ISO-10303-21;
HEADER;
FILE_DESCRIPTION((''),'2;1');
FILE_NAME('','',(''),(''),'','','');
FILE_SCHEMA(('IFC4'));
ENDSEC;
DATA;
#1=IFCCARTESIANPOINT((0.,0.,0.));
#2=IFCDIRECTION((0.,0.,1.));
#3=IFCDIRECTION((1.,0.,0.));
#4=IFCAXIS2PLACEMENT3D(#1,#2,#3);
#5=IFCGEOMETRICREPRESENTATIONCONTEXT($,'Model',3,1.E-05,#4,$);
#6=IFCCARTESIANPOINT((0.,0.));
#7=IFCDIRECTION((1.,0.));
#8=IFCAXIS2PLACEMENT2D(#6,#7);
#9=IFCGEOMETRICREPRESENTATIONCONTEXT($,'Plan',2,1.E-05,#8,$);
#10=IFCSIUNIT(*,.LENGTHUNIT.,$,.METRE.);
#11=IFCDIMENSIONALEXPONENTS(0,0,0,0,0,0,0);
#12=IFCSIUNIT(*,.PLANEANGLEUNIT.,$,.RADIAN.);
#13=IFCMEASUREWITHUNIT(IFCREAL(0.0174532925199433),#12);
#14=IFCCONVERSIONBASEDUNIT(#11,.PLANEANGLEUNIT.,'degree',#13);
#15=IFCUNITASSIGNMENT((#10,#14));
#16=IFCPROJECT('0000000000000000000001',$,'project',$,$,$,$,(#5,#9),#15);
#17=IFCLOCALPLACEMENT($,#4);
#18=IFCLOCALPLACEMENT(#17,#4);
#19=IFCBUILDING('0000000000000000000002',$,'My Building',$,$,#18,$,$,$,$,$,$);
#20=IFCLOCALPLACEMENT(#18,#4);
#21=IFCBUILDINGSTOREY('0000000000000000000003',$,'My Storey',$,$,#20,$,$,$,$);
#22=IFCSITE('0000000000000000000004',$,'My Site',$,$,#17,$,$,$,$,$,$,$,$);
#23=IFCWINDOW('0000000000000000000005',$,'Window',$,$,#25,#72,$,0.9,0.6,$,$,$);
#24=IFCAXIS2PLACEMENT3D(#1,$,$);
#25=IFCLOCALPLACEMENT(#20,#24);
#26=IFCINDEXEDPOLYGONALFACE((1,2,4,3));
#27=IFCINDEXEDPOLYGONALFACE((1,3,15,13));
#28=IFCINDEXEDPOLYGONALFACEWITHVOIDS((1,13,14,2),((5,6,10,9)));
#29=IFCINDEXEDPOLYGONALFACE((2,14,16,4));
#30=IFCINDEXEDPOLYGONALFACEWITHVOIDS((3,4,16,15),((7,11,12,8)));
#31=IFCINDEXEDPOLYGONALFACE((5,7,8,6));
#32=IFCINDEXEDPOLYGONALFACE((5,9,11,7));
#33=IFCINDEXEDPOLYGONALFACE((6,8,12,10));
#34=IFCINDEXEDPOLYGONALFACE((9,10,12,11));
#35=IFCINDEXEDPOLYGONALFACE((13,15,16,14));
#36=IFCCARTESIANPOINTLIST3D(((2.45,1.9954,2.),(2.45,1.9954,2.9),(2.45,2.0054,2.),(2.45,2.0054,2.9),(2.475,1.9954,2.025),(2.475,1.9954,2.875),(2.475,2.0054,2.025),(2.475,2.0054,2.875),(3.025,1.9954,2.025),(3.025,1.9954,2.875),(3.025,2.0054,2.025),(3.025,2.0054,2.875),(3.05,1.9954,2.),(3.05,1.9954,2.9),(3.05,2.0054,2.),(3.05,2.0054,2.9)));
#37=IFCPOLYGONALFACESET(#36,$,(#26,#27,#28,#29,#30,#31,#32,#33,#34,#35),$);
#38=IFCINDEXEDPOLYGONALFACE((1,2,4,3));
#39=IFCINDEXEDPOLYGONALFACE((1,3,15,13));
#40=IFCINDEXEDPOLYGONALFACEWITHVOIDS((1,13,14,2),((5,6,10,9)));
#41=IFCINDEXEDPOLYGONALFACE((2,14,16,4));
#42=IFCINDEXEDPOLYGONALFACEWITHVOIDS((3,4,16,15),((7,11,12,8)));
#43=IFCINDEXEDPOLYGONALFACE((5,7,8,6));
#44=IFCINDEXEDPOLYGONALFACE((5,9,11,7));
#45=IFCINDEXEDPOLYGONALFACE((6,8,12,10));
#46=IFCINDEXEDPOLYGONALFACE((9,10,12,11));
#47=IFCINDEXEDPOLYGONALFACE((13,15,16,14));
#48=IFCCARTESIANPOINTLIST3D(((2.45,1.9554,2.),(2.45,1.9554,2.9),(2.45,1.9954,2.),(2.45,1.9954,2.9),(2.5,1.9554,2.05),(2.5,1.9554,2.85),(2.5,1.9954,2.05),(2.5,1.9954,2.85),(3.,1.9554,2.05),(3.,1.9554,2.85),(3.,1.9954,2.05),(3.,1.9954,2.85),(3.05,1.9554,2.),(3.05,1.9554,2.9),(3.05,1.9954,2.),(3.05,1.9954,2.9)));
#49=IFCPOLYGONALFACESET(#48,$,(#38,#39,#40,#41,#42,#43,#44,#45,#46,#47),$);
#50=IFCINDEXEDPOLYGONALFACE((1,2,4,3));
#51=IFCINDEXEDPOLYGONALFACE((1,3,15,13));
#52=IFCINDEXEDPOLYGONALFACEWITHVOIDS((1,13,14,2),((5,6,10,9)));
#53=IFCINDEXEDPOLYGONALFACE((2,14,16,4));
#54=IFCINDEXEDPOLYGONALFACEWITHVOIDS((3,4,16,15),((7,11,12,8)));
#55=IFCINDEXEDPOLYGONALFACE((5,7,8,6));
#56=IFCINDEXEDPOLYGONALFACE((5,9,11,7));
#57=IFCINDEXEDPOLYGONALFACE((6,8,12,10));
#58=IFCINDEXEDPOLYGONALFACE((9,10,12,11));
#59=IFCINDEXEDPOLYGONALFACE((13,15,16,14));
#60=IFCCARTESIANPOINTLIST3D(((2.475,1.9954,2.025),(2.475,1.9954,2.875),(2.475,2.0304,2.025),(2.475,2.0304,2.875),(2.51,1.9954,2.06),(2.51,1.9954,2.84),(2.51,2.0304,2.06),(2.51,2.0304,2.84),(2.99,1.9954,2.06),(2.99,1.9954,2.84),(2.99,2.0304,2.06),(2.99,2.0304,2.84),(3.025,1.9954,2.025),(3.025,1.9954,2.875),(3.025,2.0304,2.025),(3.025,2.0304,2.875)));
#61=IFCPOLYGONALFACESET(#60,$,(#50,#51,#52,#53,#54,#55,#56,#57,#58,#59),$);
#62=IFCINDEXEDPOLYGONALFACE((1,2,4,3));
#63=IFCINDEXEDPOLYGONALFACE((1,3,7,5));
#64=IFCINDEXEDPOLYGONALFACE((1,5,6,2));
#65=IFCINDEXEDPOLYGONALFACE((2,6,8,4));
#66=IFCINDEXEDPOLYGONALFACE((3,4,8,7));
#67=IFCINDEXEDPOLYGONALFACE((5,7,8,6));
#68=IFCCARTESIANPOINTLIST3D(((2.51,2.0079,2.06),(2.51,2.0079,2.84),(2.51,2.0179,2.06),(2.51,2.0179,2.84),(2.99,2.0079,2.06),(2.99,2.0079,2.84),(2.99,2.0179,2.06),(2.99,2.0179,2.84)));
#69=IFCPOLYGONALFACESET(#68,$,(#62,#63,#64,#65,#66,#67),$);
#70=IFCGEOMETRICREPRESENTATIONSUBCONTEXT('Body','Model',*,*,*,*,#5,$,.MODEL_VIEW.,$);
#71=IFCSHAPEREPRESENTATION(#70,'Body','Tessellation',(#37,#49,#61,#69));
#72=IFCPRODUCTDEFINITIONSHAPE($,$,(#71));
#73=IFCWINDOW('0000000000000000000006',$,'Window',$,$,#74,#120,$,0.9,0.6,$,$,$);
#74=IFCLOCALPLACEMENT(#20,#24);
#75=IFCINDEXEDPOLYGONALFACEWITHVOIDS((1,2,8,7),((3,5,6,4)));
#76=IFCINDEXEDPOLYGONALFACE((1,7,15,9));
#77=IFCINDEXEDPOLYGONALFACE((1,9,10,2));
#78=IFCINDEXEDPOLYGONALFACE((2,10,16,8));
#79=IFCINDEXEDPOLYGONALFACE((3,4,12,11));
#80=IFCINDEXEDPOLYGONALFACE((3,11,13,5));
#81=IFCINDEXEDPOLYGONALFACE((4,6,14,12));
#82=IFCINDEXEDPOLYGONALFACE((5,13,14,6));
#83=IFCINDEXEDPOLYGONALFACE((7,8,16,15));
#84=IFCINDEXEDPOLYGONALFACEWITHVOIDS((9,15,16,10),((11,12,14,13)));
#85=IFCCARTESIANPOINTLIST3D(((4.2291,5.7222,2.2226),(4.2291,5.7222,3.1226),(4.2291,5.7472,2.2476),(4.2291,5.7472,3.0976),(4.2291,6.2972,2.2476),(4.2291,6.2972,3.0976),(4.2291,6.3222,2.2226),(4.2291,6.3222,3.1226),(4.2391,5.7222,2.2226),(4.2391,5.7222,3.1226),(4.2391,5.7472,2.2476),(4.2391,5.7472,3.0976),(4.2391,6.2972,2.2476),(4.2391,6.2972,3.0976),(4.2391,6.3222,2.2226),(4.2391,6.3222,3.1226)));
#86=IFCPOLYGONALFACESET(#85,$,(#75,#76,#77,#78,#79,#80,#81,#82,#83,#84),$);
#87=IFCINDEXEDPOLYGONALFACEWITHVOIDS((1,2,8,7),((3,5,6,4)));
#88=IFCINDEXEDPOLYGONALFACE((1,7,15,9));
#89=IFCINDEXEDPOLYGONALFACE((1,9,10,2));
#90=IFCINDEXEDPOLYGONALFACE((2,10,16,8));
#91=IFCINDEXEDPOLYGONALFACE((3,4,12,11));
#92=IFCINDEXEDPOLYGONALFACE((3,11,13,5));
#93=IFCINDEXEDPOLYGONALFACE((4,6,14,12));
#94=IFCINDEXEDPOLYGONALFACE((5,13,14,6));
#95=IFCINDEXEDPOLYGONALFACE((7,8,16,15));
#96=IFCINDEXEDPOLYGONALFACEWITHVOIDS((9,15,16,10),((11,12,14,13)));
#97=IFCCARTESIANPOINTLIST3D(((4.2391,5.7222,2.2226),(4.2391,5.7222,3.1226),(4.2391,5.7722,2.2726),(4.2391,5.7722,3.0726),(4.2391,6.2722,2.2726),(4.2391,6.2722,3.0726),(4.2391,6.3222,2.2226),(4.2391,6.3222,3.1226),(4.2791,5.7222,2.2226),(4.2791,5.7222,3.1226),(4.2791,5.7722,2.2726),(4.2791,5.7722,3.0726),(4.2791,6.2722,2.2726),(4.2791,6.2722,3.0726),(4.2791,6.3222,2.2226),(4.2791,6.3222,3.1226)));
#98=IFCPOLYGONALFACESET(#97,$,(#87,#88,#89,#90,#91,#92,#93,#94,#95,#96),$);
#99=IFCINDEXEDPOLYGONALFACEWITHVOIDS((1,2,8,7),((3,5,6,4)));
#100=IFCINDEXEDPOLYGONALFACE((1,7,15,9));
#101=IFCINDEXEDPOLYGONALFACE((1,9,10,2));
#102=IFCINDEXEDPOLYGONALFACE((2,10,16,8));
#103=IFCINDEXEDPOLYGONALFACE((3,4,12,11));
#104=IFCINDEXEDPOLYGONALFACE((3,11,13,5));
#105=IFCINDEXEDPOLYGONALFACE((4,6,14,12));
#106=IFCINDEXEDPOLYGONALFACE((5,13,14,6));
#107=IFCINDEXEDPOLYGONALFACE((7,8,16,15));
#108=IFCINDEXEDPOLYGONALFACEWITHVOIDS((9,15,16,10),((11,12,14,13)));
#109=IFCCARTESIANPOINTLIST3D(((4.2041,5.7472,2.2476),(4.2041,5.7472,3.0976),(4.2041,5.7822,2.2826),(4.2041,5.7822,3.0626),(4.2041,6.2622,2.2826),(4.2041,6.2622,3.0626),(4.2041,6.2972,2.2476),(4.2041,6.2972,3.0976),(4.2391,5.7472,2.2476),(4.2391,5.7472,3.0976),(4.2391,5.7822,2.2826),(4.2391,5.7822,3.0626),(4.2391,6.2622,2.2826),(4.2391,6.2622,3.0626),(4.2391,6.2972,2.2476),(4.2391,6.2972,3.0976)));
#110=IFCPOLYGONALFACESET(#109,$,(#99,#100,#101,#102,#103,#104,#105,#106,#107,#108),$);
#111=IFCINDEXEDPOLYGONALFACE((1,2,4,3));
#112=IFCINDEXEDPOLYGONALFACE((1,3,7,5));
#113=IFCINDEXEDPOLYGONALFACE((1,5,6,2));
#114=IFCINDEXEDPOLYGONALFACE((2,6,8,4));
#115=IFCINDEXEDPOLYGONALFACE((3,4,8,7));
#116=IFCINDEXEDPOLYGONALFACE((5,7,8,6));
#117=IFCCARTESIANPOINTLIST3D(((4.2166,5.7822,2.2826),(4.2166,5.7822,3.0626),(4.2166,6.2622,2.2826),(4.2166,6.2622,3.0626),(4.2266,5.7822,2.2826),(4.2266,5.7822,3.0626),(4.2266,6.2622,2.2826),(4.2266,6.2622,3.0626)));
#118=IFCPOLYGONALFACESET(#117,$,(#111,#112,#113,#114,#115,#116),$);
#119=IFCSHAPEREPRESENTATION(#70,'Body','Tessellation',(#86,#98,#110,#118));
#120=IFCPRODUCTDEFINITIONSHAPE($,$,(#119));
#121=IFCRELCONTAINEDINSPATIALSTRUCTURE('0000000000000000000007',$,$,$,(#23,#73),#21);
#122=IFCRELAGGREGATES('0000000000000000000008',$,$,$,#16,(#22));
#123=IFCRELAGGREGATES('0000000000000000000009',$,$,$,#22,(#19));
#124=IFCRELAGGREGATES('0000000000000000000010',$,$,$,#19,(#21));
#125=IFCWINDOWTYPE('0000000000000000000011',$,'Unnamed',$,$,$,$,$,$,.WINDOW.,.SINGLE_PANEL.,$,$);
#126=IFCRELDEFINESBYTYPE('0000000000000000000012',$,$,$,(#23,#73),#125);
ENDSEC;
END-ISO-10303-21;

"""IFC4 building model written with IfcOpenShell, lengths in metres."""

from ifc_helpers import new_model, entity, si_unit, converted_unit, frame, origin_with_axes, origin_2d_with_axis, place, context, subcontext, project, spatial, line, indexed_curve, outline, extrude, shape, source, transform, mapped, type_object, type_shapes, element, save


model = new_model("IFC4")

# Units and contexts
model_context = context("Model", 3, precision=1e-05, world=origin_with_axes())
plan_context = context("Plan", 2, precision=1e-05, world=origin_2d_with_axis())
body_context_1 = subcontext(model_context, "Body", "Model", "MODEL_VIEW")
body_context_2 = subcontext(plan_context, "Body", "Plan", "PLAN_VIEW")
ifc_project = project(units=[si_unit("LENGTHUNIT", "METRE"), converted_unit("PLANEANGLEUNIT", "degree", entity("IfcReal", 0.0174532925199433), si_unit("PLANEANGLEUNIT", "RADIAN"), dimensions=[0, 0, 0, 0, 0, 0, 0])], contexts=[model_context, plan_context])

# Site, building, storey
site_placement = place(None, origin_with_axes())
site = spatial("IfcSite", under=ifc_project, at=site_placement, Name="My Site")
building_placement = place(site_placement, origin_with_axes())
building = spatial("IfcBuilding", under=site, at=building_placement, Name="My Building")
storey_placement = place(building_placement, origin_with_axes())
storey = spatial("IfcBuildingStorey", under=building, at=storey_placement, Name="My Storey")

# Windows
window_type = type_object("IfcWindowType", Name="Unnamed", PartitioningType="SINGLE_PANEL", PredefinedType="WINDOW")
shared_shape_1 = source(origin_with_axes(), body_context_1, "Body", "SolidModel", [
    extrude(outline(indexed_curve([(0.0, 0.0), (0.6, 0.0), (0.6, 0.9), (0.0, 0.9)], segments=[line(1, 2, 3, 4, 1)]), holes=[indexed_curve([(0.025, 0.025), (0.575, 0.025), (0.575, 0.875), (0.025, 0.875)], segments=[line(1, 2, 3, 4, 1)])]), frame((0.0, 0.09, 0.0), z_axis=(0.0, -1.0, 0.0), x_axis=(1.0, 0.0, 0.0)), (0.0, 0.0, -1.0), 0.01),
    extrude(outline(indexed_curve([(0.0, 0.0), (0.6, 0.0), (0.6, 0.9), (0.0, 0.9)], segments=[line(1, 2, 3, 4, 1)]), holes=[indexed_curve([(0.05, 0.05), (0.55, 0.05), (0.55, 0.85), (0.05, 0.85)], segments=[line(1, 2, 3, 4, 1)])]), frame((0.0, 0.05, 0.0), z_axis=(0.0, -1.0, 0.0), x_axis=(1.0, 0.0, 0.0)), (0.0, 0.0, -1.0), 0.04),
    extrude(outline(indexed_curve([(0.0, 0.0), (0.55, 0.0), (0.55, 0.85), (0.0, 0.85)], segments=[line(1, 2, 3, 4, 1)]), holes=[indexed_curve([(0.035, 0.035), (0.515, 0.035), (0.515, 0.815), (0.035, 0.815)], segments=[line(1, 2, 3, 4, 1)])]), frame((0.025, 0.09, 0.025), z_axis=(0.0, -1.0, 0.0), x_axis=(1.0, 0.0, 0.0)), (0.0, 0.0, -1.0), 0.035),
    extrude(outline(indexed_curve([(0.035, 0.035), (0.515, 0.035), (0.515, 0.815), (0.035, 0.815)], segments=[line(1, 2, 3, 4, 1)])), frame((0.025, 0.1025, 0.025), z_axis=(0.0, -1.0, 0.0), x_axis=(1.0, 0.0, 0.0)), (0.0, 0.0, -1.0), 0.01),
])
shared_shape_2 = source(origin_with_axes(), body_context_2, "Body", "Curve2D", [
    entity("IfcIndexedPolyCurve", entity("IfcCartesianPointList2D", [[0.05, 0.05], [0.55, 0.05]])),
    entity("IfcIndexedPolyCurve", entity("IfcCartesianPointList2D", [[0.0, 0.1], [0.025, 0.1], [0.025, 0.09], [0.05, 0.09], [0.05, 0.05], [0.0, 0.05]]), [entity("IfcLineIndex", [1, 2, 3, 4, 5, 6, 1])]),
    entity("IfcIndexedPolyCurve", entity("IfcCartesianPointList2D", [[0.6, 0.1], [0.575, 0.1], [0.575, 0.09], [0.55, 0.09], [0.55, 0.05], [0.6, 0.05]]), [entity("IfcLineIndex", [1, 2, 3, 4, 5, 6, 1])]),
    entity("IfcIndexedPolyCurve", entity("IfcCartesianPointList2D", [[0.025, 0.09], [0.06, 0.09], [0.06, 0.125], [0.025, 0.125]]), [entity("IfcLineIndex", [1, 2, 3, 4, 1])]),
    entity("IfcIndexedPolyCurve", entity("IfcCartesianPointList2D", [[0.575, 0.09], [0.54, 0.09], [0.54, 0.125], [0.575, 0.125]]), [entity("IfcLineIndex", [1, 2, 3, 4, 1])]),
    entity("IfcIndexedPolyCurve", entity("IfcCartesianPointList2D", [[0.06, 0.09], [0.54, 0.09]])),
    entity("IfcIndexedPolyCurve", entity("IfcCartesianPointList2D", [[0.06, 0.125], [0.54, 0.125]])),
    entity("IfcIndexedPolyCurve", entity("IfcCartesianPointList2D", [[0.06, 0.1075], [0.54, 0.1075]])),
])
type_shapes(window_type, [shared_shape_1, shared_shape_2])
for number, where, z_axis, x_axis, name in (
    (1, (2.45, 1.9054, 2.0), (0.0, 0.0, 1.0), (1.0, 0.0, 0.0), "Window"),
    (2, (4.3291, 5.7222, 2.2226), (0.0, 0.0, 1.0), (0.0, 1.0, 0.0), "Window"),
):
    element("IfcWindow", number, at=place(storey_placement, frame(where, z_axis=z_axis, x_axis=x_axis)), inside=storey, type_object=window_type, Name=name, OverallHeight=0.9, OverallWidth=0.6, shapes=[
        shape(body_context_1, "Body", "MappedRepresentation", [mapped(shared_shape_1, transform((0.0, 0.0, 0.0), x_axis=(1.0, 0.0, 0.0), y_axis=(0.0, 1.0, 0.0), z_axis=(0.0, 0.0, 1.0), scale=1.0))]),
        shape(body_context_2, "Body", "MappedRepresentation", [mapped(shared_shape_2, transform((0.0, 0.0, 0.0), x_axis=(1.0, 0.0, 0.0), y_axis=(0.0, 1.0, 0.0), z_axis=(0.0, 0.0, 1.0), scale=1.0))]),
    ])

save(model, "model.ifc")
